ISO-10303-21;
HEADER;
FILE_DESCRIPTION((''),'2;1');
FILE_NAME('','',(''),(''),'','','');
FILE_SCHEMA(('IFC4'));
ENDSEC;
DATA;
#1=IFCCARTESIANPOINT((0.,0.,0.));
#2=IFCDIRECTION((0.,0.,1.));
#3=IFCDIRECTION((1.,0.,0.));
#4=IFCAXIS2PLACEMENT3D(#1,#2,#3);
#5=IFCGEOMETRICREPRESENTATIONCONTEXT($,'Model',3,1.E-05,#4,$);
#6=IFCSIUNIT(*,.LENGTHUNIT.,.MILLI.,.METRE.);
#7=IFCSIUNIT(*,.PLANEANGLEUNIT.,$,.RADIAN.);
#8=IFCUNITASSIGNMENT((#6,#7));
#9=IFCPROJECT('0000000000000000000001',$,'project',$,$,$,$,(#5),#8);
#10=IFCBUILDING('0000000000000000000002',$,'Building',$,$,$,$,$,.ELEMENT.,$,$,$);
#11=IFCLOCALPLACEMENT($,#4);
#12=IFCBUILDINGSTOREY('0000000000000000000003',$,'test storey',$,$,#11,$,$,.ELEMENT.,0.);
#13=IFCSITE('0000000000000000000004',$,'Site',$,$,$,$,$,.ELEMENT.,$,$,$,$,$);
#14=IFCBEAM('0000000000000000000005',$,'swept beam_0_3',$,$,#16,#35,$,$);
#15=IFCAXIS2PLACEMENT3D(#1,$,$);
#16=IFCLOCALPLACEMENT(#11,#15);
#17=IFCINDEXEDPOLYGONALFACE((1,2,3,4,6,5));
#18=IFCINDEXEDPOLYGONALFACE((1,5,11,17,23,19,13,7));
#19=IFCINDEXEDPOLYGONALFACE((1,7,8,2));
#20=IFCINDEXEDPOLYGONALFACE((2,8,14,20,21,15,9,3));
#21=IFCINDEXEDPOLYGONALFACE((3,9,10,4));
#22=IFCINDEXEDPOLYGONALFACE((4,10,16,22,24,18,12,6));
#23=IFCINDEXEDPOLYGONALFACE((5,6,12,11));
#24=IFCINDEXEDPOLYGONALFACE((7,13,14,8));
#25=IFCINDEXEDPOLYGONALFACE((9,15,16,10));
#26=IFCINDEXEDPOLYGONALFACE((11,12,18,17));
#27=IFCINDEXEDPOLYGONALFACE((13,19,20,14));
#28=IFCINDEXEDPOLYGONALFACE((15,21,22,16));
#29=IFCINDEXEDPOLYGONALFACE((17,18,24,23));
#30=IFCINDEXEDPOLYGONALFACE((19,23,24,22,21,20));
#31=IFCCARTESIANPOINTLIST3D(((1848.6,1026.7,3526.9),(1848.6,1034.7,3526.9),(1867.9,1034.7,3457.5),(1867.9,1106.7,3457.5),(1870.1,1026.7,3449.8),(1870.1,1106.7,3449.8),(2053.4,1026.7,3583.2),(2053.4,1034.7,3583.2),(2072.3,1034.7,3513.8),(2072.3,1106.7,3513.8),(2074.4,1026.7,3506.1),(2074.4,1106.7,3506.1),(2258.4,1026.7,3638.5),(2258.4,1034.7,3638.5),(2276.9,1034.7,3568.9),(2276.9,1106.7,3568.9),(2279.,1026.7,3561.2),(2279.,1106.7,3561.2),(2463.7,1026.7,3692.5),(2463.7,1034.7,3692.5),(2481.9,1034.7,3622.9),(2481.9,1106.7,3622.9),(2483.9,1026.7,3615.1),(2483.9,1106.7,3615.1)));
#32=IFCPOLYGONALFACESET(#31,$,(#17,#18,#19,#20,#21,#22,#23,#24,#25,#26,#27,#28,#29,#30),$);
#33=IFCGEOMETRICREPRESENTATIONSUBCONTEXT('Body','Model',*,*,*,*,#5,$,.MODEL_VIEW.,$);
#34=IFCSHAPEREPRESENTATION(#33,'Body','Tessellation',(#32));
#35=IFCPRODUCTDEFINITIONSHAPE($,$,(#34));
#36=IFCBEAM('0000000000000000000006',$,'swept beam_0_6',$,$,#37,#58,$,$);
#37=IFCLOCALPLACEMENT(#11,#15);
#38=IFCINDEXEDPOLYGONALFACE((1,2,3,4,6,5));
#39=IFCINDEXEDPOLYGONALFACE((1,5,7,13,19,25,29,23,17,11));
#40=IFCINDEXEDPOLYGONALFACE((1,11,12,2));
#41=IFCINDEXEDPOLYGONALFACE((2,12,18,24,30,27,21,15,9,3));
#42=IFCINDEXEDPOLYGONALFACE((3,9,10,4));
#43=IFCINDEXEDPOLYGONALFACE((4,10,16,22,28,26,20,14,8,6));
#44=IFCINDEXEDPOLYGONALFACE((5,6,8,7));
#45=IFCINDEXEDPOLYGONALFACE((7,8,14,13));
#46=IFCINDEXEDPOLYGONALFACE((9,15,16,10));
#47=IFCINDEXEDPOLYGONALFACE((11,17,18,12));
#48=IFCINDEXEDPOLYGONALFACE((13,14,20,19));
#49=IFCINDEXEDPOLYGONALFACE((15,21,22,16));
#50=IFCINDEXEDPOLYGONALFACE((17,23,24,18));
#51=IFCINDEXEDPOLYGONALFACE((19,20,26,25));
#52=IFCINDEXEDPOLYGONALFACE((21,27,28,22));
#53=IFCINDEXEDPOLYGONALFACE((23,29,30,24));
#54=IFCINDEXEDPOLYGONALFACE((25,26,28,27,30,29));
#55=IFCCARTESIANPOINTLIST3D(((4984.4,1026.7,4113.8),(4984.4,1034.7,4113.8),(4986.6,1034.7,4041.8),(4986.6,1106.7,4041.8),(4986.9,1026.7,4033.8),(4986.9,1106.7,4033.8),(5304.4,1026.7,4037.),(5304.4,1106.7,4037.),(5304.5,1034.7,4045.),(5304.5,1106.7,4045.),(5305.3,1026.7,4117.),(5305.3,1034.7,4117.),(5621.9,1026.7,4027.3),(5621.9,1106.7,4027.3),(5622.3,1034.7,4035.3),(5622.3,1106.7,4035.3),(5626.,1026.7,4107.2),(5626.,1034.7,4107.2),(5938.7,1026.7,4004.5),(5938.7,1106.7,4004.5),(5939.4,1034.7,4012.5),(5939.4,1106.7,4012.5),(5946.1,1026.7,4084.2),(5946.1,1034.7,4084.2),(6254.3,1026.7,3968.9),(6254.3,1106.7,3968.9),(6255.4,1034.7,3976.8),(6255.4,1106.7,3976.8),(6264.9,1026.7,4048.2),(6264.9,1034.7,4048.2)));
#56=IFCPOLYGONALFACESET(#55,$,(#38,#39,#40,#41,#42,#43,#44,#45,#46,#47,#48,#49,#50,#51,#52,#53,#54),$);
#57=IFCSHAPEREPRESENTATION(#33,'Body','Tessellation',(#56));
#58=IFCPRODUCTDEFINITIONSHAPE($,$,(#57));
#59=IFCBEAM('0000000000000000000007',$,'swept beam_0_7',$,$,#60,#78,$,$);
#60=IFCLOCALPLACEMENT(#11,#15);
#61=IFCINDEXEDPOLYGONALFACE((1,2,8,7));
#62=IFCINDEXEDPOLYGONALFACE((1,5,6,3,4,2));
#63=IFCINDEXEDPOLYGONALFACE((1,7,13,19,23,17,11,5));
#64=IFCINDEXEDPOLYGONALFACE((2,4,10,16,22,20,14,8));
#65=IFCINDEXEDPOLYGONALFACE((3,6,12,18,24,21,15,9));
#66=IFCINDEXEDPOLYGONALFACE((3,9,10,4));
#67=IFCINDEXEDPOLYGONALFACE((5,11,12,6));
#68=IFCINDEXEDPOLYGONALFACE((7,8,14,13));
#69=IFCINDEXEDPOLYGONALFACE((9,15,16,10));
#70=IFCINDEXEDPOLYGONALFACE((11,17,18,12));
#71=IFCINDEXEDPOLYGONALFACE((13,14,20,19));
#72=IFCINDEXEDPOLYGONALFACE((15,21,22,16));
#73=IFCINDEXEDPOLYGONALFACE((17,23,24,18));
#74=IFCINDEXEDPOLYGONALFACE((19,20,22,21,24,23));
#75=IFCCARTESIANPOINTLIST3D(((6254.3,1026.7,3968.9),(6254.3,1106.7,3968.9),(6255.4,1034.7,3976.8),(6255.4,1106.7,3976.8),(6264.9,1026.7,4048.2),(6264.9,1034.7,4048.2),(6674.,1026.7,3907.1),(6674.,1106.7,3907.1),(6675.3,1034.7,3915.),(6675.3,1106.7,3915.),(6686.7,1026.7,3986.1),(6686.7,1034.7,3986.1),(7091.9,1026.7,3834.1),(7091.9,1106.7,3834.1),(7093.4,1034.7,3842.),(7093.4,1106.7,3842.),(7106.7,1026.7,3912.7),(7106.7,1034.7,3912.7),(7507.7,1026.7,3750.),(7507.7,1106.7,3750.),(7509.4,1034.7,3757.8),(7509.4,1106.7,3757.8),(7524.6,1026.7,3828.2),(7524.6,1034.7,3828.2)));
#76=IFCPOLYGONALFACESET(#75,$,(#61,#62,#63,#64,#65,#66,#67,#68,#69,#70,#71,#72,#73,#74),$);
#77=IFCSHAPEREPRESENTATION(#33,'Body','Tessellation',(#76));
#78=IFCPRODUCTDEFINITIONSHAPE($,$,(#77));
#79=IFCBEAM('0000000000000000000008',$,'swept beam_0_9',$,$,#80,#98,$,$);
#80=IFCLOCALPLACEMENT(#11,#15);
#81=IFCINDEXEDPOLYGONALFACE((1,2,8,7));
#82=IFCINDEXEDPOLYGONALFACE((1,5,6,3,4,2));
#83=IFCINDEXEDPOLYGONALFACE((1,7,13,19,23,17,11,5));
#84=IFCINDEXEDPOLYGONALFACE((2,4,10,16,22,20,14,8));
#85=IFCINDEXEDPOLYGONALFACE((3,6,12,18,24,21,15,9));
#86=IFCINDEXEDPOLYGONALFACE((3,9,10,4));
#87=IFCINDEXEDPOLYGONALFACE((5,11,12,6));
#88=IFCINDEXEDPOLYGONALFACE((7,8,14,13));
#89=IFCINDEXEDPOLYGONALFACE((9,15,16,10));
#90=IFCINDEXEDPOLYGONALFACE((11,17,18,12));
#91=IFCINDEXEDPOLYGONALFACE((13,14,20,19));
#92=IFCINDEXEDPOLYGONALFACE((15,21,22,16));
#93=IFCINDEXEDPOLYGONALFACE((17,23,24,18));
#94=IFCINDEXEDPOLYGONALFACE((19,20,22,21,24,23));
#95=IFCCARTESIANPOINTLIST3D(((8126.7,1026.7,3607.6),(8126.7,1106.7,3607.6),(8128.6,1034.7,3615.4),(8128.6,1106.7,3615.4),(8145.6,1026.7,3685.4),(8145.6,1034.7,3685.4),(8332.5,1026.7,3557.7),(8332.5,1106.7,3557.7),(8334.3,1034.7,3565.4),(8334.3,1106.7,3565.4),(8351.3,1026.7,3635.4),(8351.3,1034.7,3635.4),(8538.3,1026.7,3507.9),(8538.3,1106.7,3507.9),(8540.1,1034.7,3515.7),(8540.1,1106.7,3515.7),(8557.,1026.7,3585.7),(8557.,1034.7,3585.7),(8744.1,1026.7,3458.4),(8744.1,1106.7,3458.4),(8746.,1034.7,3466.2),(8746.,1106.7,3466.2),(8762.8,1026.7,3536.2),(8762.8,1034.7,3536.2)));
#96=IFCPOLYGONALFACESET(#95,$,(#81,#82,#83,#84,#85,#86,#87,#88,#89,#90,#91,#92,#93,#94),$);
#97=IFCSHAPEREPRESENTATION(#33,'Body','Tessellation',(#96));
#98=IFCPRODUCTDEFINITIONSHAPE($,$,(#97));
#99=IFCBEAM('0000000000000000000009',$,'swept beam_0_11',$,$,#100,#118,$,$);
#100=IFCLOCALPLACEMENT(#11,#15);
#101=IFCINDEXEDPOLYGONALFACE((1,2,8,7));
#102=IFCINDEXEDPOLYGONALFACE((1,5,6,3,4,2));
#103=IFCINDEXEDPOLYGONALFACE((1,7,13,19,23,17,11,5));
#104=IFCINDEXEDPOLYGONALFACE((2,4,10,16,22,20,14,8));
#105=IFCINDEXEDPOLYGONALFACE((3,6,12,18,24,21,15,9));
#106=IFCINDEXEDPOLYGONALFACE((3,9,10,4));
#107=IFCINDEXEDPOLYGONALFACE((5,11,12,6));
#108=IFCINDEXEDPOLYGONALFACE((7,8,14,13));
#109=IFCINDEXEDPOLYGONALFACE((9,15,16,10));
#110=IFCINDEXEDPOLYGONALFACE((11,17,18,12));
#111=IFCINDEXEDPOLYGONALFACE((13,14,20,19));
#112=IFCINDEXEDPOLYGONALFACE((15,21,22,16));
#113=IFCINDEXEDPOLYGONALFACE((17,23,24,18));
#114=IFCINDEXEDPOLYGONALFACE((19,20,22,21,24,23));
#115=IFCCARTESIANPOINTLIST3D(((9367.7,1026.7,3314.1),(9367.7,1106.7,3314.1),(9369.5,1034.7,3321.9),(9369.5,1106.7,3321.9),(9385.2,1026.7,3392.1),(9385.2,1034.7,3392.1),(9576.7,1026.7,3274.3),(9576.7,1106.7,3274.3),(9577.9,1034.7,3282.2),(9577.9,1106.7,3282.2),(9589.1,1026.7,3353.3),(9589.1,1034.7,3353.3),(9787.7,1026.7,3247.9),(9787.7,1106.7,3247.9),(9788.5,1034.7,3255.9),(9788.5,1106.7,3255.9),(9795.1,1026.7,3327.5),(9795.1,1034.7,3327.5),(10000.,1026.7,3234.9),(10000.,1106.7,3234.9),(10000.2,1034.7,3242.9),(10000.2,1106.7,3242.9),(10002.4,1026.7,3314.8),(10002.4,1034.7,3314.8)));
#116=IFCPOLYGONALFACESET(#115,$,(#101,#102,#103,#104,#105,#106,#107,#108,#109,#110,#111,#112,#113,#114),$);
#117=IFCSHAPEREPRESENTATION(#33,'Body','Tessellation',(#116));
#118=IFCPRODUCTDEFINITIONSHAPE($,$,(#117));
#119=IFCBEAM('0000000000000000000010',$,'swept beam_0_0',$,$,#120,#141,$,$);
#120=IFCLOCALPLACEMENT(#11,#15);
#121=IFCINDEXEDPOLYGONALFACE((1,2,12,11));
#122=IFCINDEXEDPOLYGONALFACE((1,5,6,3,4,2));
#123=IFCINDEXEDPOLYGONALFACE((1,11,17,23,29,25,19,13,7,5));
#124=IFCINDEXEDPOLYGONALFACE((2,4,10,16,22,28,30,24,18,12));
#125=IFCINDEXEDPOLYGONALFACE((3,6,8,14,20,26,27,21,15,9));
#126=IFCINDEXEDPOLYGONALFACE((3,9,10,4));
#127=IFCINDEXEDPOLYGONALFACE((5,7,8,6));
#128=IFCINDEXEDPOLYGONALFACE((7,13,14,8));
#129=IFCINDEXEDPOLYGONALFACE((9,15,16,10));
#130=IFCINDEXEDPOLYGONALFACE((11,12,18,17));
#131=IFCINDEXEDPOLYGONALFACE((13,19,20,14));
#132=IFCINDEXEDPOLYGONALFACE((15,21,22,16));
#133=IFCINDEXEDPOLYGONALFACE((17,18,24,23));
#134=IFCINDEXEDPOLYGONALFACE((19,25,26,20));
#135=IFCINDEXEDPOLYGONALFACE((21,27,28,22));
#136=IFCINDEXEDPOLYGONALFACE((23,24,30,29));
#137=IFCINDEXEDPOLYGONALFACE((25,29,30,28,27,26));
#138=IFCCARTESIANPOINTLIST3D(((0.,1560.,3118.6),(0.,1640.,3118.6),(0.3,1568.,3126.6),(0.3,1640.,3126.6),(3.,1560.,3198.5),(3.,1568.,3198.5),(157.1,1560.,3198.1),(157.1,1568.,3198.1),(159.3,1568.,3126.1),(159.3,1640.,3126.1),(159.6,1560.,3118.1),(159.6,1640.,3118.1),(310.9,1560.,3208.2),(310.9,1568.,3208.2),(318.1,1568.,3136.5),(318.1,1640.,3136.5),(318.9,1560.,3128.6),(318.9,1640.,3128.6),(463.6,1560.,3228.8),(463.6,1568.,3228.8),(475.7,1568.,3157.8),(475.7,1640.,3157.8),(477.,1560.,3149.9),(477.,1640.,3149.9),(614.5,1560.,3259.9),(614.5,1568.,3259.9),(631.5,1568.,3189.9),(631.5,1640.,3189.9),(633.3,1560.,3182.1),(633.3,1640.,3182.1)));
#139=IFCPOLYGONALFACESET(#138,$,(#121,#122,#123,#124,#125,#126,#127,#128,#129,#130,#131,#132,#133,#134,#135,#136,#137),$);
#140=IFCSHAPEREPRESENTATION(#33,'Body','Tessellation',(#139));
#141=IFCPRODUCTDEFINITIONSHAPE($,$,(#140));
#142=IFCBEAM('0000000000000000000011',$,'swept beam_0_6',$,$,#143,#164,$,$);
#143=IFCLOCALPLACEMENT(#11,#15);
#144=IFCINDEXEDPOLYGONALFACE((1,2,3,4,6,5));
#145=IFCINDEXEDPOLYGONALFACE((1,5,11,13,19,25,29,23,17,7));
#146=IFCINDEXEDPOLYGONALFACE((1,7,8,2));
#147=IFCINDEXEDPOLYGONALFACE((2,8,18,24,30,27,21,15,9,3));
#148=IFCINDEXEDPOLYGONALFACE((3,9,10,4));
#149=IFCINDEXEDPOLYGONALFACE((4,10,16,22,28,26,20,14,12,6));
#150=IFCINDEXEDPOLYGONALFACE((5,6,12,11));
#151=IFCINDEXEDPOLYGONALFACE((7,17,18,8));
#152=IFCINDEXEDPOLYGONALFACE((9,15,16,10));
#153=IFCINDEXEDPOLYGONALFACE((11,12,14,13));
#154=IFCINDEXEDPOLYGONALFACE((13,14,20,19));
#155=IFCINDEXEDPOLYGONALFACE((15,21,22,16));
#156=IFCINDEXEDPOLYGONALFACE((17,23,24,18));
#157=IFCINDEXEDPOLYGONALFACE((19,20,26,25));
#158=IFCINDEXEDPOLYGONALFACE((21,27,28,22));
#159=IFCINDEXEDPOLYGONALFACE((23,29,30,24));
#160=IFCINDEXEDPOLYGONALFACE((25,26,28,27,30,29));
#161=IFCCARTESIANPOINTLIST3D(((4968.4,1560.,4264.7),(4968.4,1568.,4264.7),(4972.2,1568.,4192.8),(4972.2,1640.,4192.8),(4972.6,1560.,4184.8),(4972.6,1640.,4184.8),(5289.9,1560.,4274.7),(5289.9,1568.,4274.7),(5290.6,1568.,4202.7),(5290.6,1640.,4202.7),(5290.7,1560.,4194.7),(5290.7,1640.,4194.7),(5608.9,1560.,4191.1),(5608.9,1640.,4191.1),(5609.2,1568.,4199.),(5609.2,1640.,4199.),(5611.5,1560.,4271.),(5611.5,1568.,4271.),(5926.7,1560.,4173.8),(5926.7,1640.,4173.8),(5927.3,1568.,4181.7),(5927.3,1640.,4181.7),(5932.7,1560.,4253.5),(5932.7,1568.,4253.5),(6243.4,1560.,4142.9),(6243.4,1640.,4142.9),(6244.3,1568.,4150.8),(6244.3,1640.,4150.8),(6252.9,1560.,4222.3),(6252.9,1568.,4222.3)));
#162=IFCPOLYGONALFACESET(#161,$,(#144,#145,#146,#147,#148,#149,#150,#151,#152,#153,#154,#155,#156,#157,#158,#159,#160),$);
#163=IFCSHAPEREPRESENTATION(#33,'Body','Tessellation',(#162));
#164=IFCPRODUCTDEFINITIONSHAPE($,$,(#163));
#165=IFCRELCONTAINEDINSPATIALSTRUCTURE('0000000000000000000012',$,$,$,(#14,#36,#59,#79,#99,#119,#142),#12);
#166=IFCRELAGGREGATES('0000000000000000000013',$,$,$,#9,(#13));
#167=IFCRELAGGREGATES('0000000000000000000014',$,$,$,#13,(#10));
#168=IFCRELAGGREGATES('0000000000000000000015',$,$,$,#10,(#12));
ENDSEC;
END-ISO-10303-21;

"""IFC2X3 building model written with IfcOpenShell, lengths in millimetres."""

from ifc_helpers import new_model, entity, si_unit, origin_with_axes, place, context, subcontext, project, spatial, element, save


model = new_model("IFC2X3")

# Units and contexts
model_context = context("Model", 3, precision=1e-05, world=origin_with_axes())
body_context = subcontext(model_context, "Body", "Model", "MODEL_VIEW")
ifc_project = project(units=[si_unit("LENGTHUNIT", "METRE", prefix="MILLI"), si_unit("PLANEANGLEUNIT", "RADIAN")], contexts=[model_context])

# Site, building, storey
site = spatial("IfcSite", under=ifc_project, Name="Site", CompositionType="ELEMENT")
building = spatial("IfcBuilding", under=site, Name="Building", CompositionType="ELEMENT")
storey_placement = place(None, origin_with_axes())
storey = spatial("IfcBuildingStorey", under=building, at=storey_placement, Name="test storey", CompositionType="ELEMENT", Elevation=0.0)

# Beams
beam_1_placement = place(storey_placement, origin_with_axes())
element("IfcBeam", 1, at=beam_1_placement, inside=storey, Name="swept beam_0_3", context=body_context, shape_type="SweptSolid", body=[
    entity("IfcRevolvedAreaSolid", entity("IfcArbitraryClosedProfileDef", "AREA", None, entity("IfcPolyline", [entity("IfcCartesianPoint", [80.0, -40.0]), entity("IfcCartesianPoint", [80.0, -32.0]), entity("IfcCartesianPoint", [8.0, -32.0]), entity("IfcCartesianPoint", [8.0, 40.0]), entity("IfcCartesianPoint", [0.0, 40.0]), entity("IfcCartesianPoint", [0.0, -40.0]), entity("IfcCartesianPoint", [80.0, -40.0])])), entity("IfcAxis2Placement3D", entity("IfcCartesianPoint", [1870.1, 1066.7, 3449.8]), entity("IfcDirection", [-0.9634, 0.0, -0.2682]), entity("IfcDirection", [-0.2682, 0.0, 0.9634])), entity("IfcAxis1Placement", entity("IfcCartesianPoint", [-37717.8, 0.0, 0.0]), entity("IfcDirection", [0.0, 1.0, 0.0])), 0.016853),
])
beam_2_placement = place(storey_placement, origin_with_axes())
element("IfcBeam", 2, at=beam_2_placement, inside=storey, Name="swept beam_0_6", context=body_context, shape_type="SweptSolid", body=[
    entity("IfcRevolvedAreaSolid", entity("IfcArbitraryClosedProfileDef", "AREA", None, entity("IfcPolyline", [entity("IfcCartesianPoint", [80.0, -40.0]), entity("IfcCartesianPoint", [80.0, -32.0]), entity("IfcCartesianPoint", [8.0, -32.0]), entity("IfcCartesianPoint", [8.0, 40.0]), entity("IfcCartesianPoint", [0.0, 40.0]), entity("IfcCartesianPoint", [0.0, -40.0]), entity("IfcCartesianPoint", [80.0, -40.0])])), entity("IfcAxis2Placement3D", entity("IfcCartesianPoint", [4986.9, 1066.7, 4033.8]), entity("IfcDirection", [-0.9995, 0.0, -0.0305]), entity("IfcDirection", [-0.0305, 0.0, 0.9995])), entity("IfcAxis1Placement", entity("IfcCartesianPoint", [-7778.6, 0.0, 0.0]), entity("IfcDirection", [0.0, 1.0, 0.0])), 0.163336),
])
beam_3_placement = place(storey_placement, origin_with_axes())
element("IfcBeam", 3, at=beam_3_placement, inside=storey, Name="swept beam_0_7", context=body_context, shape_type="SweptSolid", body=[
    entity("IfcRevolvedAreaSolid", entity("IfcArbitraryClosedProfileDef", "AREA", None, entity("IfcPolyline", [entity("IfcCartesianPoint", [80.0, -40.0]), entity("IfcCartesianPoint", [80.0, -32.0]), entity("IfcCartesianPoint", [8.0, -32.0]), entity("IfcCartesianPoint", [8.0, 40.0]), entity("IfcCartesianPoint", [0.0, 40.0]), entity("IfcCartesianPoint", [0.0, -40.0]), entity("IfcCartesianPoint", [80.0, -40.0])])), entity("IfcAxis2Placement3D", entity("IfcCartesianPoint", [6254.3, 1066.7, 3968.9]), entity("IfcDirection", [-0.9912, 0.0, 0.1324]), entity("IfcDirection", [0.1324, 0.0, 0.9912])), entity("IfcAxis1Placement", entity("IfcCartesianPoint", [-15847.8, 0.0, 0.0]), entity("IfcDirection", [0.0, 1.0, 0.0])), 0.080306),
])
beam_4_placement = place(storey_placement, origin_with_axes())
element("IfcBeam", 4, at=beam_4_placement, inside=storey, Name="swept beam_0_9", context=body_context, shape_type="SweptSolid", body=[
    entity("IfcRevolvedAreaSolid", entity("IfcArbitraryClosedProfileDef", "AREA", None, entity("IfcPolyline", [entity("IfcCartesianPoint", [-80.0, 40.0]), entity("IfcCartesianPoint", [-80.0, 32.0]), entity("IfcCartesianPoint", [-8.0, 32.0]), entity("IfcCartesianPoint", [-8.0, -40.0]), entity("IfcCartesianPoint", [0.0, -40.0]), entity("IfcCartesianPoint", [0.0, 40.0]), entity("IfcCartesianPoint", [-80.0, 40.0])])), entity("IfcAxis2Placement3D", entity("IfcCartesianPoint", [8126.7, 1066.7, 3607.6]), entity("IfcDirection", [-0.9716, 0.0, 0.2365]), entity("IfcDirection", [-0.2365, 0.0, -0.9716])), entity("IfcAxis1Placement", entity("IfcCartesianPoint", [-188030.1, 0.0, 0.0]), entity("IfcDirection", [0.0, 1.0, 0.0])), 0.003378),
])
beam_5_placement = place(storey_placement, origin_with_axes())
element("IfcBeam", 5, at=beam_5_placement, inside=storey, Name="swept beam_0_11", context=body_context, shape_type="SweptSolid", body=[
    entity("IfcRevolvedAreaSolid", entity("IfcArbitraryClosedProfileDef", "AREA", None, entity("IfcPolyline", [entity("IfcCartesianPoint", [-80.0, 40.0]), entity("IfcCartesianPoint", [-80.0, 32.0]), entity("IfcCartesianPoint", [-8.0, 32.0]), entity("IfcCartesianPoint", [-8.0, -40.0]), entity("IfcCartesianPoint", [0.0, -40.0]), entity("IfcCartesianPoint", [0.0, 40.0]), entity("IfcCartesianPoint", [-80.0, 40.0])])), entity("IfcAxis2Placement3D", entity("IfcCartesianPoint", [9367.7, 1066.7, 3314.1]), entity("IfcDirection", [-0.976, 0.0, 0.2179]), entity("IfcDirection", [-0.2179, 0.0, -0.976])), entity("IfcAxis1Placement", entity("IfcCartesianPoint", [-3357.1, 0.0, 0.0]), entity("IfcDirection", [0.0, 1.0, 0.0])), 0.190096),
])
beam_6_placement = place(storey_placement, origin_with_axes())
element("IfcBeam", 6, at=beam_6_placement, inside=storey, Name="swept beam_0_0", context=body_context, shape_type="SweptSolid", body=[
    entity("IfcRevolvedAreaSolid", entity("IfcArbitraryClosedProfileDef", "AREA", None, entity("IfcPolyline", [entity("IfcCartesianPoint", [-80.0, 40.0]), entity("IfcCartesianPoint", [-80.0, 32.0]), entity("IfcCartesianPoint", [-8.0, 32.0]), entity("IfcCartesianPoint", [-8.0, -40.0]), entity("IfcCartesianPoint", [0.0, -40.0]), entity("IfcCartesianPoint", [0.0, 40.0]), entity("IfcCartesianPoint", [-80.0, 40.0])])), entity("IfcAxis2Placement3D", entity("IfcCartesianPoint", [0.0, 1600.0, 3118.6]), entity("IfcDirection", [-0.9993, 0.0, 0.0373]), entity("IfcDirection", [-0.0373, 0.0, -0.9993])), entity("IfcAxis1Placement", entity("IfcCartesianPoint", [-2325.7, 0.0, 0.0]), entity("IfcDirection", [0.0, 1.0, 0.0])), 0.274546),
])
beam_7_placement = place(storey_placement, origin_with_axes())
element("IfcBeam", 7, at=beam_7_placement, inside=storey, Name="swept beam_0_6", context=body_context, shape_type="SweptSolid", body=[
    entity("IfcRevolvedAreaSolid", entity("IfcArbitraryClosedProfileDef", "AREA", None, entity("IfcPolyline", [entity("IfcCartesianPoint", [80.0, -40.0]), entity("IfcCartesianPoint", [80.0, -32.0]), entity("IfcCartesianPoint", [8.0, -32.0]), entity("IfcCartesianPoint", [8.0, 40.0]), entity("IfcCartesianPoint", [0.0, 40.0]), entity("IfcCartesianPoint", [0.0, -40.0]), entity("IfcCartesianPoint", [80.0, -40.0])])), entity("IfcAxis2Placement3D", entity("IfcCartesianPoint", [4972.6, 1600.0, 4184.8]), entity("IfcDirection", [-0.9986, 0.0, -0.0526]), entity("IfcDirection", [-0.0526, 0.0, 0.9986])), entity("IfcAxis1Placement", entity("IfcCartesianPoint", [-7434.6, 0.0, 0.0]), entity("IfcDirection", [0.0, 1.0, 0.0])), 0.171231),
])

save(model, "model.ifc")
